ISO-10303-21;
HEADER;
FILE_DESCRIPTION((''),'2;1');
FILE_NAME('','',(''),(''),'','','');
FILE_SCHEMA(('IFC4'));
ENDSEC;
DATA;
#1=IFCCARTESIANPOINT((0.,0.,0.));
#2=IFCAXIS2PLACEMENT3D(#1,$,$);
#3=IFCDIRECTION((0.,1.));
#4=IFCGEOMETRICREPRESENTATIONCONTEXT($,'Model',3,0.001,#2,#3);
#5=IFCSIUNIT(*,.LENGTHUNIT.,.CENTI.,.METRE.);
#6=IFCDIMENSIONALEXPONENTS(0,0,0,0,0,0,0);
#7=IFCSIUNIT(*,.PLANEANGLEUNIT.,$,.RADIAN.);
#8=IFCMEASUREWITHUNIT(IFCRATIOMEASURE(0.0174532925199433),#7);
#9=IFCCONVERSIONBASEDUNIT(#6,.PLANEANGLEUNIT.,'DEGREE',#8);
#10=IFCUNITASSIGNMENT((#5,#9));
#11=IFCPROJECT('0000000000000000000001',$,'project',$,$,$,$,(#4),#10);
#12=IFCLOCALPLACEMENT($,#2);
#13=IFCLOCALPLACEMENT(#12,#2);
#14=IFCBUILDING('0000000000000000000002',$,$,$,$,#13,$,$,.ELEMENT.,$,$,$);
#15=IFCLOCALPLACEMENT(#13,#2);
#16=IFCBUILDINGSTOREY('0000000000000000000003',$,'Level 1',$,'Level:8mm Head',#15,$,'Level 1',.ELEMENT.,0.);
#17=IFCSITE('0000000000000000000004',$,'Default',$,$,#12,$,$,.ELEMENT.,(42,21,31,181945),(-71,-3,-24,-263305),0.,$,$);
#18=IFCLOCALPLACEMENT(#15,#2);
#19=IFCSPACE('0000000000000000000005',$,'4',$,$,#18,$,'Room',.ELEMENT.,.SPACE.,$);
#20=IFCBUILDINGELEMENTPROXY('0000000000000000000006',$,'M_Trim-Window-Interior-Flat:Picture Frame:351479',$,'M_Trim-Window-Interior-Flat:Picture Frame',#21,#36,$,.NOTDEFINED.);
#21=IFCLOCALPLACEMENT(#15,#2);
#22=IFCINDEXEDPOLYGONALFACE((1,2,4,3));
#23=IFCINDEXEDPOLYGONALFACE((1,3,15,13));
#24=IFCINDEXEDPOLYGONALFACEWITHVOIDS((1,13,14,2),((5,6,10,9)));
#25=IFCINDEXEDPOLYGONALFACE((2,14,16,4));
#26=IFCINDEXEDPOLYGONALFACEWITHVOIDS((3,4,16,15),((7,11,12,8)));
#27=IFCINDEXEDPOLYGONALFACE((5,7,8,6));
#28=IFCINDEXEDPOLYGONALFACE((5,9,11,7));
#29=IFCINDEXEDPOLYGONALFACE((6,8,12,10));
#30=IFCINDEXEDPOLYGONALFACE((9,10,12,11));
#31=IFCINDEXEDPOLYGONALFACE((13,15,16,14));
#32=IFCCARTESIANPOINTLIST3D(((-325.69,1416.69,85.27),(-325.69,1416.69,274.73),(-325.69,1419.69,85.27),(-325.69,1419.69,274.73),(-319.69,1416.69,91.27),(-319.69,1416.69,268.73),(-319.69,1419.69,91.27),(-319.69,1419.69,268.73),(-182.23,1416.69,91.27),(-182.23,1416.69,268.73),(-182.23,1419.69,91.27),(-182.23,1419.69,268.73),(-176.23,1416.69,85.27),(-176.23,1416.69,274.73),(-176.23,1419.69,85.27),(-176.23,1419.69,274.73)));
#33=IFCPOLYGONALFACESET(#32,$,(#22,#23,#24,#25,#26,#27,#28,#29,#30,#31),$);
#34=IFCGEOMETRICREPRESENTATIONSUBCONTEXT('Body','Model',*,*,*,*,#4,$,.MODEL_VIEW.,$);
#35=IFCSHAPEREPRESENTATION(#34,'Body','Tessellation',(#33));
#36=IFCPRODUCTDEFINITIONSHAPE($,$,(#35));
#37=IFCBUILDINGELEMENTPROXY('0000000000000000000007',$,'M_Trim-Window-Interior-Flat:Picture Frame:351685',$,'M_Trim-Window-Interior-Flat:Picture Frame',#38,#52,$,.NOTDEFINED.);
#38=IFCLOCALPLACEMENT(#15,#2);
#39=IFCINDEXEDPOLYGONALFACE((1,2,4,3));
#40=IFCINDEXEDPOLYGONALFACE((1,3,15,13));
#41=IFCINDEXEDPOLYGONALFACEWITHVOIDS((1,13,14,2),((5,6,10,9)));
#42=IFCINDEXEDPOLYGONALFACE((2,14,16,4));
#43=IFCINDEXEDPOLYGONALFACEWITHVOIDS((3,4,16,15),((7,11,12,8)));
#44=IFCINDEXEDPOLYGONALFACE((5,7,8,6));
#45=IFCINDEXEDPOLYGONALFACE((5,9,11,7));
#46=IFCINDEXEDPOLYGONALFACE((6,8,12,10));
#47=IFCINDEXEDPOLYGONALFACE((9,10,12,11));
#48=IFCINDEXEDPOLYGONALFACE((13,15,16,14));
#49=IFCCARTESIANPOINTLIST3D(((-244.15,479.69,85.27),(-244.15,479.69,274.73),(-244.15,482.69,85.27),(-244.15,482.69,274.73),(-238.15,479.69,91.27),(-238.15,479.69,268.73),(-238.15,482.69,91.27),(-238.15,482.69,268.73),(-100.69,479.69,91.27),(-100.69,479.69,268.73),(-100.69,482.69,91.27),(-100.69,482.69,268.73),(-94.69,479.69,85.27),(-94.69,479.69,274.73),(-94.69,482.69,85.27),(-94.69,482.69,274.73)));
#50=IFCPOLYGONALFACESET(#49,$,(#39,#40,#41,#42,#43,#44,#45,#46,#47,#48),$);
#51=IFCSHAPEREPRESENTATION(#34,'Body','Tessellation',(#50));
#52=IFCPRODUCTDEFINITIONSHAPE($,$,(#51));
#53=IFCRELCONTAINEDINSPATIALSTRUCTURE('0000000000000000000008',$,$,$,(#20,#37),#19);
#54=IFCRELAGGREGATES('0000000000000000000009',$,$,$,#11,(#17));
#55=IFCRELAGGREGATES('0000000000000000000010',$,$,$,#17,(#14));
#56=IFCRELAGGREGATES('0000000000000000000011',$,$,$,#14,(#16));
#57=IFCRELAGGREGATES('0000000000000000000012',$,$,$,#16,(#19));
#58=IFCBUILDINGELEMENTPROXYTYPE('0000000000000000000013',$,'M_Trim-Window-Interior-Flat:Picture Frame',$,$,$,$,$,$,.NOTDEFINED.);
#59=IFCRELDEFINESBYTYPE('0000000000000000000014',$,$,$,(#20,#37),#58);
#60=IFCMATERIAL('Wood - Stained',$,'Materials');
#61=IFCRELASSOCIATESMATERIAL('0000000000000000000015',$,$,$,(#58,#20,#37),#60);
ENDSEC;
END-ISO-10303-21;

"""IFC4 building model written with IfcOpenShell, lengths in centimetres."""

from ifc_helpers import new_model, entity, si_unit, converted_unit, direction, frame, origin, place, context, subcontext, project, spatial, polyline, outline, extrude, source, transform, mapped, material, type_object, type_shapes, element, save


model = new_model("IFC4")

# Units and contexts
model_context = context("Model", 3, precision=0.001, world=origin(), true_north=direction((0.0, 1.0)))
body_context = subcontext(model_context, "Body", "Model", "MODEL_VIEW")
ifc_project = project(units=[si_unit("LENGTHUNIT", "METRE", prefix="CENTI"), converted_unit("PLANEANGLEUNIT", "DEGREE", entity("IfcRatioMeasure", 0.0174532925199433), si_unit("PLANEANGLEUNIT", "RADIAN"), dimensions=[0, 0, 0, 0, 0, 0, 0])], contexts=[model_context])

# Site, building, storey
site_placement = place(None, origin())
site = spatial("IfcSite", under=ifc_project, at=site_placement, Name="Default", CompositionType="ELEMENT", RefLatitude=(42, 21, 31, 181945), RefLongitude=(-71, -3, -24, -263305), RefElevation=0.0)
building_placement = place(site_placement, origin())
building = spatial("IfcBuilding", under=site, at=building_placement, CompositionType="ELEMENT")
storey_placement = place(building_placement, origin())
storey = spatial("IfcBuildingStorey", under=building, at=storey_placement, Name="Level 1", ObjectType="Level:8mm Head", LongName="Level 1", CompositionType="ELEMENT", Elevation=0.0)

# Shared definitions
space_placement = place(storey_placement, origin())
space = spatial("IfcSpace", under=storey, at=space_placement, Name="4", LongName="Room", CompositionType="ELEMENT", PredefinedType="SPACE")

# Building element proxies
ifc_material_1 = material(Name="Wood - Stained", Category="Materials")
building_element_proxy_type_1 = type_object("IfcBuildingElementProxyType", Name="M_Trim-Window-Interior-Flat:Picture Frame", PredefinedType="NOTDEFINED", material=ifc_material_1)
shared_shape_1 = source(origin(), body_context, "Body", "SweptSolid", [
    extrude(outline(polyline([(-74.73, -94.73), (74.73, -94.73), (74.73, 94.73), (-74.73, 94.73), (-74.73, -94.73)]), holes=[polyline([(-68.73, -88.73), (-68.73, 88.73), (68.73, 88.73), (68.73, -88.73), (-68.73, -88.73)])]), frame((0.0, -90.0, 0.0), z_axis=(0.0, 0.0, 1.0), x_axis=(-1.0, 0.0, 0.0)), (0.0, 0.0, 1.0), 3.0),
])
type_shapes(building_element_proxy_type_1, [shared_shape_1])
for number, where, z_axis, x_axis, name in (
    (1, (-250.96, 1419.69, 270.0), (0.0, -1.0, 0.0), (1.0, 0.0, 0.0), "M_Trim-Window-Interior-Flat:Picture Frame:351479"),
    (2, (-169.42, 479.69, 270.0), (0.0, 1.0, 0.0), (-1.0, 0.0, 0.0), "M_Trim-Window-Interior-Flat:Picture Frame:351685"),
):
    element("IfcBuildingElementProxy", number, at=place(space_placement, frame(where, z_axis=z_axis, x_axis=x_axis)), inside=space, type_object=building_element_proxy_type_1, material=ifc_material_1, Name=name, ObjectType="M_Trim-Window-Interior-Flat:Picture Frame", PredefinedType="NOTDEFINED", context=body_context, shape_type="MappedRepresentation", body=[
        mapped(shared_shape_1, transform((0.0, 0.0, 0.0), scale=1.0)),
    ])

save(model, "model.ifc")
